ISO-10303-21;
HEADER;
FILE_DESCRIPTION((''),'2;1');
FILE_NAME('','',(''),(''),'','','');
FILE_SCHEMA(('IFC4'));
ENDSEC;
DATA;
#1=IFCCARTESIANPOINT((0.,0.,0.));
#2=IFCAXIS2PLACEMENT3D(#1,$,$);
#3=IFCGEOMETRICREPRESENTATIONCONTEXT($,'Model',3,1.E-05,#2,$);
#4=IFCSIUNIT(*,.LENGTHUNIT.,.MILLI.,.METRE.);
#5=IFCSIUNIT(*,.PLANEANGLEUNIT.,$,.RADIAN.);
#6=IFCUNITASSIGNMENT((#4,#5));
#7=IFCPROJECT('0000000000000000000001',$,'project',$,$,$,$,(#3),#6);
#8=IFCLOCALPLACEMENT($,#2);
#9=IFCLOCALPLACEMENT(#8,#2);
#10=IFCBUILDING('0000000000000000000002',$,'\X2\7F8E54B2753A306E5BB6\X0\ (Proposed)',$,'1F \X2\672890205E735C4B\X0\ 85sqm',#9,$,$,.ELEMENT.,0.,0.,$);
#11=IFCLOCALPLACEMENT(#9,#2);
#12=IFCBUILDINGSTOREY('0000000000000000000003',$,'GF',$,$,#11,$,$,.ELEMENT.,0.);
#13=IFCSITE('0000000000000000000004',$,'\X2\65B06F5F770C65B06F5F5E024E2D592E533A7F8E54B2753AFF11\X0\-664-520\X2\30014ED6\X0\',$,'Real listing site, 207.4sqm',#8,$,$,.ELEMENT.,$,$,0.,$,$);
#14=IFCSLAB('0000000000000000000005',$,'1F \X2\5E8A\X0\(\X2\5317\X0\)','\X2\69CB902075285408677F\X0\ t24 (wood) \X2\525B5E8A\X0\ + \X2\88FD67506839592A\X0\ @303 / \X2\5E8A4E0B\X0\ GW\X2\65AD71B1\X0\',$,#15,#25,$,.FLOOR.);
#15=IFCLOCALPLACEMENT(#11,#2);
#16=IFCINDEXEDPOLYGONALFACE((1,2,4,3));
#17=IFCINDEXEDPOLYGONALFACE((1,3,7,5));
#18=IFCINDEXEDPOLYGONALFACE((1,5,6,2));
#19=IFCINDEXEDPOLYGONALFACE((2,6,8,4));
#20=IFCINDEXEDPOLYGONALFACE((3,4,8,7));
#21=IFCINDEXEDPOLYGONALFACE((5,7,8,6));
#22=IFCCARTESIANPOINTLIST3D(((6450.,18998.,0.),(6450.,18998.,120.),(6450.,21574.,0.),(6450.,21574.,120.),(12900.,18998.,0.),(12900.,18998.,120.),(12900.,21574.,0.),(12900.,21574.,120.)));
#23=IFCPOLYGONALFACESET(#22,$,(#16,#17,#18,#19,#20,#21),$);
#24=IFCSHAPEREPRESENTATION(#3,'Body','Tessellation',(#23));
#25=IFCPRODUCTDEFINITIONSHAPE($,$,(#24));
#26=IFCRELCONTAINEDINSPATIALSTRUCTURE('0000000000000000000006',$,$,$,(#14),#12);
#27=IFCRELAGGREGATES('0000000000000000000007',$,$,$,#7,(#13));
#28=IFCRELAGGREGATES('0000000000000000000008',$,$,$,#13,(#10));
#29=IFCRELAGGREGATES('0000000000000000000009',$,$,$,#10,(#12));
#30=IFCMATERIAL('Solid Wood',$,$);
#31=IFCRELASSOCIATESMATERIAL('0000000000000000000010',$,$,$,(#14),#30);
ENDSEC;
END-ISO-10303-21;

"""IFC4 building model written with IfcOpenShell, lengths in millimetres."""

from ifc_helpers import new_model, si_unit, frame, frame_2d, origin, place, context, project, spatial, rectangle, extrude, material, element, save


model = new_model("IFC4")

# Units and contexts
model_context = context("Model", 3, precision=1e-05, world=origin())
ifc_project = project(units=[si_unit("LENGTHUNIT", "METRE", prefix="MILLI"), si_unit("PLANEANGLEUNIT", "RADIAN")], contexts=[model_context])

# Site, building, storey
site_placement = place(None, origin())
site = spatial("IfcSite", under=ifc_project, at=site_placement, Name="新潟県新潟市中央区美咲町１-664-520、他", ObjectType="Real listing site, 207.4sqm", CompositionType="ELEMENT", RefElevation=0.0)
building_placement = place(site_placement, origin())
building = spatial("IfcBuilding", under=site, at=building_placement, Name="美咲町の家 (Proposed)", ObjectType="1F 木造平屋 85sqm", CompositionType="ELEMENT", ElevationOfRefHeight=0.0, ElevationOfTerrain=0.0)
storey_placement = place(building_placement, origin())
storey = spatial("IfcBuildingStorey", under=building, at=storey_placement, Name="GF", CompositionType="ELEMENT", Elevation=0.0)

# Slab
ifc_material_1 = material(Name="Solid Wood")
slab_1_placement = place(storey_placement, frame((3225.0, 9499.0, 0.0)))
element("IfcSlab", 1, at=slab_1_placement, inside=storey, material=ifc_material_1, Name="1F 床(北)", Description="構造用合板 t24 (wood) 剛床 + 製材根太 @303 / 床下 GW断熱", PredefinedType="FLOOR", context=model_context, shape_type="SweptSolid", body=[
    extrude(rectangle(XDim=6450.0, YDim=2576.0, at=frame_2d((3225.0, 1288.0))), frame((3225.0, 9499.0, 0.0)), (0.0, 0.0, 1.0), 120.0),
])

save(model, "model.ifc")
